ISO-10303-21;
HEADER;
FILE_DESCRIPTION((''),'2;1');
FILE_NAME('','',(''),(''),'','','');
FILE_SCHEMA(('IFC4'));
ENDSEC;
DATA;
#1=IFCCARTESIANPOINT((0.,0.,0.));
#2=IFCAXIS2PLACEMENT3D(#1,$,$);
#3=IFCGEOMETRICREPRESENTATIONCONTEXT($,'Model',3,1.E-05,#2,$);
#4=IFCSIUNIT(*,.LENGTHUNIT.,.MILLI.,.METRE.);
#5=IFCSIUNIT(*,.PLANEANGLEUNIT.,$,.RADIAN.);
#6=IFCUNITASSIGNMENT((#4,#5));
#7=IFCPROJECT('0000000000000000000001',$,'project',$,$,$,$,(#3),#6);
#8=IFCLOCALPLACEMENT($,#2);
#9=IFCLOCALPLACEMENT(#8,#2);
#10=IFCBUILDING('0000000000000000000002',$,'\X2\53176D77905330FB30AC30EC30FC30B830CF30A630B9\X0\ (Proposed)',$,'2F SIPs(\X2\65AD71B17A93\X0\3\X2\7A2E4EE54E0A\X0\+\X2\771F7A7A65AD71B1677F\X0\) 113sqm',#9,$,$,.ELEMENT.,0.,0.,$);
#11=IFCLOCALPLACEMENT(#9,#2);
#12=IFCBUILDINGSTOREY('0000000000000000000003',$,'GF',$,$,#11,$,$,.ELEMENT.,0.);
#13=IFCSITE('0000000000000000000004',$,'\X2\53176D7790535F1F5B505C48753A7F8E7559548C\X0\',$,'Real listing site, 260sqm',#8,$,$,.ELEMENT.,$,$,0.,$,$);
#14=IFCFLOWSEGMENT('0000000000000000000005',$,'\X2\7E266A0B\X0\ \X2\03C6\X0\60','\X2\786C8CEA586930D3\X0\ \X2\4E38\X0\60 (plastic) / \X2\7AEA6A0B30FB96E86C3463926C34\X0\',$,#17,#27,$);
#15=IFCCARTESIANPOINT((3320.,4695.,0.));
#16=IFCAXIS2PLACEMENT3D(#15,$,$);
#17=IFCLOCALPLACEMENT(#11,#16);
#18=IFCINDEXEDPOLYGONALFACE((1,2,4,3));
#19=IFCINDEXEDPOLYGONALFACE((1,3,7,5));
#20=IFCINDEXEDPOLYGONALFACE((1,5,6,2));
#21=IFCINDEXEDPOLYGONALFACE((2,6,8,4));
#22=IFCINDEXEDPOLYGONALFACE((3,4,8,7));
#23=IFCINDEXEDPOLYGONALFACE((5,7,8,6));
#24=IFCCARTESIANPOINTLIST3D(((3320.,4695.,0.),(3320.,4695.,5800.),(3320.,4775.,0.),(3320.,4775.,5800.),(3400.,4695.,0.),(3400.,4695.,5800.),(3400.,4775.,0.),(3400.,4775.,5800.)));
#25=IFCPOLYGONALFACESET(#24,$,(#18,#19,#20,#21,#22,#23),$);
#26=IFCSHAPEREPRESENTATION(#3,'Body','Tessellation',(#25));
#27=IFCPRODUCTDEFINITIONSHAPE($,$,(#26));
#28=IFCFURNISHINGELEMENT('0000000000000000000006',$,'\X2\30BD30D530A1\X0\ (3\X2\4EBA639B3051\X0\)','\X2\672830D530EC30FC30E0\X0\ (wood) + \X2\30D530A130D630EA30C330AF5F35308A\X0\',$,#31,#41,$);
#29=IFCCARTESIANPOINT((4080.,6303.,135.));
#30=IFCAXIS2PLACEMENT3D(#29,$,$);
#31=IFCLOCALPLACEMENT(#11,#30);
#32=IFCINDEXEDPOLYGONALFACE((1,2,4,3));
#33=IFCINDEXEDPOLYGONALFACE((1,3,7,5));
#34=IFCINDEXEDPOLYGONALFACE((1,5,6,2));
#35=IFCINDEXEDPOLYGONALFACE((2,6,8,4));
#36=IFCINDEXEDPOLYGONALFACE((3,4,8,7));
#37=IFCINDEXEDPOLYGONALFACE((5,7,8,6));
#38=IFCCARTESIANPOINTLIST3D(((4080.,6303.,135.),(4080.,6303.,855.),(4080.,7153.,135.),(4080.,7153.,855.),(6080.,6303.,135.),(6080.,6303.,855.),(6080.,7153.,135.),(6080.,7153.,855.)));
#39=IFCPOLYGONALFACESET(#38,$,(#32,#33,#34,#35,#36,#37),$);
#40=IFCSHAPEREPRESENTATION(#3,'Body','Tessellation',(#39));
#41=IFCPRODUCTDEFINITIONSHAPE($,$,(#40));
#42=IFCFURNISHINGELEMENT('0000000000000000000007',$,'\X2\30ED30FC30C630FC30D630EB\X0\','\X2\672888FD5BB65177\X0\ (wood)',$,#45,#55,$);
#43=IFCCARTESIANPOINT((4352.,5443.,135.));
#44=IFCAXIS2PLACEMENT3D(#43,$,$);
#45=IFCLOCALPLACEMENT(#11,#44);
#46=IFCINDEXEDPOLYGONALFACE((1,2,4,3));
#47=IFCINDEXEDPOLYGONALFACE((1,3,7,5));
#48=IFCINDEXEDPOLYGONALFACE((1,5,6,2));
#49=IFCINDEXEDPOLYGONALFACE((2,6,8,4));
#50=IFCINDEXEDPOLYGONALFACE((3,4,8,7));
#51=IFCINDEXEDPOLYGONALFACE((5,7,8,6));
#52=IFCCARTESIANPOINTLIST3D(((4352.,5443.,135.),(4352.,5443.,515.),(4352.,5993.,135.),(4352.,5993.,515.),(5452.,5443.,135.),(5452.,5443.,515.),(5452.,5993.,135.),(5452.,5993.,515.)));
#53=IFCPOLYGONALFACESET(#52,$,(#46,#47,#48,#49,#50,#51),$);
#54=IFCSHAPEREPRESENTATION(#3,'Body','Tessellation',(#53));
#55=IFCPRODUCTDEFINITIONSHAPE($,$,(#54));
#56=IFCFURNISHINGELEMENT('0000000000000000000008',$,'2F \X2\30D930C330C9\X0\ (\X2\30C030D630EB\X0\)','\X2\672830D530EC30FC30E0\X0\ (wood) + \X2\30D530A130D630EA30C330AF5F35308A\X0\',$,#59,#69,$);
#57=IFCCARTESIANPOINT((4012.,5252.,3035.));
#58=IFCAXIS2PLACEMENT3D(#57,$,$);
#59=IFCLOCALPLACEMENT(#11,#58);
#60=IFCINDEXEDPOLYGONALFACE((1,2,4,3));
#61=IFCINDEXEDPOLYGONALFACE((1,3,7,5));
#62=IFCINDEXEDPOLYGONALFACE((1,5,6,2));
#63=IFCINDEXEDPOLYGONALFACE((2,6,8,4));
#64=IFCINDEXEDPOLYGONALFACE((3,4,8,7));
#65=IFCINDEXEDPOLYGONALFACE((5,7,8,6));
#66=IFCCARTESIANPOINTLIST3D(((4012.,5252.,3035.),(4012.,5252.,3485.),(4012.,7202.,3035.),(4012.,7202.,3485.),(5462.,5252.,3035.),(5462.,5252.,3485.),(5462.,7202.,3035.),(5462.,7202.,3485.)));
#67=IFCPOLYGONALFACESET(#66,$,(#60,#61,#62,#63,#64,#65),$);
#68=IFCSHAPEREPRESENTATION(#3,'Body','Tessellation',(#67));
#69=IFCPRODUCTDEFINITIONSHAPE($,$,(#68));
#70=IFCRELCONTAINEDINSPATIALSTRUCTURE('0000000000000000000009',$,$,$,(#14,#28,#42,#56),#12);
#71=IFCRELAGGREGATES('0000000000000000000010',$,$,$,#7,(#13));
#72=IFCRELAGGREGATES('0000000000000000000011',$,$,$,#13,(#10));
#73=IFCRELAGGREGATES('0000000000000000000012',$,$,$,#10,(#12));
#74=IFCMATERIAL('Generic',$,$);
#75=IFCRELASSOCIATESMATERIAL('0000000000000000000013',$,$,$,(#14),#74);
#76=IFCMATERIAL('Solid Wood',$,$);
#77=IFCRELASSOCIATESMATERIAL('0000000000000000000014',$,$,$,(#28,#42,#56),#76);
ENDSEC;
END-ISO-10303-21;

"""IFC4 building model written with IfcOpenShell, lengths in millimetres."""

from ifc_helpers import new_model, si_unit, frame, frame_2d, origin, place, context, project, spatial, rectangle, extrude, material, element, save


model = new_model("IFC4")

# Units and contexts
model_context = context("Model", 3, precision=1e-05, world=origin())
ifc_project = project(units=[si_unit("LENGTHUNIT", "METRE", prefix="MILLI"), si_unit("PLANEANGLEUNIT", "RADIAN")], contexts=[model_context])

# Site, building, storey
site_placement = place(None, origin())
site = spatial("IfcSite", under=ifc_project, at=site_placement, Name="北海道弟子屈町美留和", ObjectType="Real listing site, 260sqm", CompositionType="ELEMENT", RefElevation=0.0)
building_placement = place(site_placement, origin())
building = spatial("IfcBuilding", under=site, at=building_placement, Name="北海道・ガレージハウス (Proposed)", ObjectType="2F SIPs(断熱窓3種以上+真空断熱板) 113sqm", CompositionType="ELEMENT", ElevationOfRefHeight=0.0, ElevationOfTerrain=0.0)
storey_placement = place(building_placement, origin())
storey = spatial("IfcBuildingStorey", under=building, at=storey_placement, Name="GF", CompositionType="ELEMENT", Elevation=0.0)

# Shared definitions
ifc_material_1 = material(Name="Solid Wood")

# Shared definitions
ifc_material_2 = material(Name="Generic")

# Flow segment
flow_segment_1_placement = place(storey_placement, frame((3320.0, 4695.0, 0.0)))
element("IfcFlowSegment", 1, at=flow_segment_1_placement, inside=storey, material=ifc_material_2, Name="縦樋 φ60", Description="硬質塩ビ 丸60 (plastic) / 竪樋・雨水排水", context=model_context, shape_type="SweptSolid", body=[
    extrude(rectangle(XDim=80.0, YDim=80.0, at=frame_2d((40.0, 40.0))), frame((3320.0, 4695.0, 0.0)), (0.0, 0.0, 1.0), 5800.0),
])

# Furnishing elements
furnishing_1_placement = place(storey_placement, frame((4080.0, 6303.0, 135.0)))
element("IfcFurnishingElement", 2, at=furnishing_1_placement, inside=storey, material=ifc_material_1, Name="ソファ (3人掛け)", Description="木フレーム (wood) + ファブリック張り", context=model_context, shape_type="SweptSolid", body=[
    extrude(rectangle(XDim=2000.0, YDim=850.0, at=frame_2d((1000.0, 425.0))), frame((4080.0, 6303.0, 135.0)), (0.0, 0.0, 1.0), 720.0),
])
furnishing_2_placement = place(storey_placement, frame((4352.0, 5443.0, 135.0)))
element("IfcFurnishingElement", 3, at=furnishing_2_placement, inside=storey, material=ifc_material_1, Name="ローテーブル", Description="木製家具 (wood)", context=model_context, shape_type="SweptSolid", body=[
    extrude(rectangle(XDim=1100.0, YDim=550.0, at=frame_2d((550.0, 275.0))), frame((4352.0, 5443.0, 135.0)), (0.0, 0.0, 1.0), 380.0),
])
furnishing_3_placement = place(storey_placement, frame((4012.0, 5252.0, 3035.0)))
element("IfcFurnishingElement", 4, at=furnishing_3_placement, inside=storey, material=ifc_material_1, Name="2F ベッド (ダブル)", Description="木フレーム (wood) + ファブリック張り", context=model_context, shape_type="SweptSolid", body=[
    extrude(rectangle(XDim=1450.0, YDim=1950.0, at=frame_2d((725.0, 975.0))), frame((4012.0, 5252.0, 3035.0)), (0.0, 0.0, 1.0), 450.0),
])

save(model, "model.ifc")
